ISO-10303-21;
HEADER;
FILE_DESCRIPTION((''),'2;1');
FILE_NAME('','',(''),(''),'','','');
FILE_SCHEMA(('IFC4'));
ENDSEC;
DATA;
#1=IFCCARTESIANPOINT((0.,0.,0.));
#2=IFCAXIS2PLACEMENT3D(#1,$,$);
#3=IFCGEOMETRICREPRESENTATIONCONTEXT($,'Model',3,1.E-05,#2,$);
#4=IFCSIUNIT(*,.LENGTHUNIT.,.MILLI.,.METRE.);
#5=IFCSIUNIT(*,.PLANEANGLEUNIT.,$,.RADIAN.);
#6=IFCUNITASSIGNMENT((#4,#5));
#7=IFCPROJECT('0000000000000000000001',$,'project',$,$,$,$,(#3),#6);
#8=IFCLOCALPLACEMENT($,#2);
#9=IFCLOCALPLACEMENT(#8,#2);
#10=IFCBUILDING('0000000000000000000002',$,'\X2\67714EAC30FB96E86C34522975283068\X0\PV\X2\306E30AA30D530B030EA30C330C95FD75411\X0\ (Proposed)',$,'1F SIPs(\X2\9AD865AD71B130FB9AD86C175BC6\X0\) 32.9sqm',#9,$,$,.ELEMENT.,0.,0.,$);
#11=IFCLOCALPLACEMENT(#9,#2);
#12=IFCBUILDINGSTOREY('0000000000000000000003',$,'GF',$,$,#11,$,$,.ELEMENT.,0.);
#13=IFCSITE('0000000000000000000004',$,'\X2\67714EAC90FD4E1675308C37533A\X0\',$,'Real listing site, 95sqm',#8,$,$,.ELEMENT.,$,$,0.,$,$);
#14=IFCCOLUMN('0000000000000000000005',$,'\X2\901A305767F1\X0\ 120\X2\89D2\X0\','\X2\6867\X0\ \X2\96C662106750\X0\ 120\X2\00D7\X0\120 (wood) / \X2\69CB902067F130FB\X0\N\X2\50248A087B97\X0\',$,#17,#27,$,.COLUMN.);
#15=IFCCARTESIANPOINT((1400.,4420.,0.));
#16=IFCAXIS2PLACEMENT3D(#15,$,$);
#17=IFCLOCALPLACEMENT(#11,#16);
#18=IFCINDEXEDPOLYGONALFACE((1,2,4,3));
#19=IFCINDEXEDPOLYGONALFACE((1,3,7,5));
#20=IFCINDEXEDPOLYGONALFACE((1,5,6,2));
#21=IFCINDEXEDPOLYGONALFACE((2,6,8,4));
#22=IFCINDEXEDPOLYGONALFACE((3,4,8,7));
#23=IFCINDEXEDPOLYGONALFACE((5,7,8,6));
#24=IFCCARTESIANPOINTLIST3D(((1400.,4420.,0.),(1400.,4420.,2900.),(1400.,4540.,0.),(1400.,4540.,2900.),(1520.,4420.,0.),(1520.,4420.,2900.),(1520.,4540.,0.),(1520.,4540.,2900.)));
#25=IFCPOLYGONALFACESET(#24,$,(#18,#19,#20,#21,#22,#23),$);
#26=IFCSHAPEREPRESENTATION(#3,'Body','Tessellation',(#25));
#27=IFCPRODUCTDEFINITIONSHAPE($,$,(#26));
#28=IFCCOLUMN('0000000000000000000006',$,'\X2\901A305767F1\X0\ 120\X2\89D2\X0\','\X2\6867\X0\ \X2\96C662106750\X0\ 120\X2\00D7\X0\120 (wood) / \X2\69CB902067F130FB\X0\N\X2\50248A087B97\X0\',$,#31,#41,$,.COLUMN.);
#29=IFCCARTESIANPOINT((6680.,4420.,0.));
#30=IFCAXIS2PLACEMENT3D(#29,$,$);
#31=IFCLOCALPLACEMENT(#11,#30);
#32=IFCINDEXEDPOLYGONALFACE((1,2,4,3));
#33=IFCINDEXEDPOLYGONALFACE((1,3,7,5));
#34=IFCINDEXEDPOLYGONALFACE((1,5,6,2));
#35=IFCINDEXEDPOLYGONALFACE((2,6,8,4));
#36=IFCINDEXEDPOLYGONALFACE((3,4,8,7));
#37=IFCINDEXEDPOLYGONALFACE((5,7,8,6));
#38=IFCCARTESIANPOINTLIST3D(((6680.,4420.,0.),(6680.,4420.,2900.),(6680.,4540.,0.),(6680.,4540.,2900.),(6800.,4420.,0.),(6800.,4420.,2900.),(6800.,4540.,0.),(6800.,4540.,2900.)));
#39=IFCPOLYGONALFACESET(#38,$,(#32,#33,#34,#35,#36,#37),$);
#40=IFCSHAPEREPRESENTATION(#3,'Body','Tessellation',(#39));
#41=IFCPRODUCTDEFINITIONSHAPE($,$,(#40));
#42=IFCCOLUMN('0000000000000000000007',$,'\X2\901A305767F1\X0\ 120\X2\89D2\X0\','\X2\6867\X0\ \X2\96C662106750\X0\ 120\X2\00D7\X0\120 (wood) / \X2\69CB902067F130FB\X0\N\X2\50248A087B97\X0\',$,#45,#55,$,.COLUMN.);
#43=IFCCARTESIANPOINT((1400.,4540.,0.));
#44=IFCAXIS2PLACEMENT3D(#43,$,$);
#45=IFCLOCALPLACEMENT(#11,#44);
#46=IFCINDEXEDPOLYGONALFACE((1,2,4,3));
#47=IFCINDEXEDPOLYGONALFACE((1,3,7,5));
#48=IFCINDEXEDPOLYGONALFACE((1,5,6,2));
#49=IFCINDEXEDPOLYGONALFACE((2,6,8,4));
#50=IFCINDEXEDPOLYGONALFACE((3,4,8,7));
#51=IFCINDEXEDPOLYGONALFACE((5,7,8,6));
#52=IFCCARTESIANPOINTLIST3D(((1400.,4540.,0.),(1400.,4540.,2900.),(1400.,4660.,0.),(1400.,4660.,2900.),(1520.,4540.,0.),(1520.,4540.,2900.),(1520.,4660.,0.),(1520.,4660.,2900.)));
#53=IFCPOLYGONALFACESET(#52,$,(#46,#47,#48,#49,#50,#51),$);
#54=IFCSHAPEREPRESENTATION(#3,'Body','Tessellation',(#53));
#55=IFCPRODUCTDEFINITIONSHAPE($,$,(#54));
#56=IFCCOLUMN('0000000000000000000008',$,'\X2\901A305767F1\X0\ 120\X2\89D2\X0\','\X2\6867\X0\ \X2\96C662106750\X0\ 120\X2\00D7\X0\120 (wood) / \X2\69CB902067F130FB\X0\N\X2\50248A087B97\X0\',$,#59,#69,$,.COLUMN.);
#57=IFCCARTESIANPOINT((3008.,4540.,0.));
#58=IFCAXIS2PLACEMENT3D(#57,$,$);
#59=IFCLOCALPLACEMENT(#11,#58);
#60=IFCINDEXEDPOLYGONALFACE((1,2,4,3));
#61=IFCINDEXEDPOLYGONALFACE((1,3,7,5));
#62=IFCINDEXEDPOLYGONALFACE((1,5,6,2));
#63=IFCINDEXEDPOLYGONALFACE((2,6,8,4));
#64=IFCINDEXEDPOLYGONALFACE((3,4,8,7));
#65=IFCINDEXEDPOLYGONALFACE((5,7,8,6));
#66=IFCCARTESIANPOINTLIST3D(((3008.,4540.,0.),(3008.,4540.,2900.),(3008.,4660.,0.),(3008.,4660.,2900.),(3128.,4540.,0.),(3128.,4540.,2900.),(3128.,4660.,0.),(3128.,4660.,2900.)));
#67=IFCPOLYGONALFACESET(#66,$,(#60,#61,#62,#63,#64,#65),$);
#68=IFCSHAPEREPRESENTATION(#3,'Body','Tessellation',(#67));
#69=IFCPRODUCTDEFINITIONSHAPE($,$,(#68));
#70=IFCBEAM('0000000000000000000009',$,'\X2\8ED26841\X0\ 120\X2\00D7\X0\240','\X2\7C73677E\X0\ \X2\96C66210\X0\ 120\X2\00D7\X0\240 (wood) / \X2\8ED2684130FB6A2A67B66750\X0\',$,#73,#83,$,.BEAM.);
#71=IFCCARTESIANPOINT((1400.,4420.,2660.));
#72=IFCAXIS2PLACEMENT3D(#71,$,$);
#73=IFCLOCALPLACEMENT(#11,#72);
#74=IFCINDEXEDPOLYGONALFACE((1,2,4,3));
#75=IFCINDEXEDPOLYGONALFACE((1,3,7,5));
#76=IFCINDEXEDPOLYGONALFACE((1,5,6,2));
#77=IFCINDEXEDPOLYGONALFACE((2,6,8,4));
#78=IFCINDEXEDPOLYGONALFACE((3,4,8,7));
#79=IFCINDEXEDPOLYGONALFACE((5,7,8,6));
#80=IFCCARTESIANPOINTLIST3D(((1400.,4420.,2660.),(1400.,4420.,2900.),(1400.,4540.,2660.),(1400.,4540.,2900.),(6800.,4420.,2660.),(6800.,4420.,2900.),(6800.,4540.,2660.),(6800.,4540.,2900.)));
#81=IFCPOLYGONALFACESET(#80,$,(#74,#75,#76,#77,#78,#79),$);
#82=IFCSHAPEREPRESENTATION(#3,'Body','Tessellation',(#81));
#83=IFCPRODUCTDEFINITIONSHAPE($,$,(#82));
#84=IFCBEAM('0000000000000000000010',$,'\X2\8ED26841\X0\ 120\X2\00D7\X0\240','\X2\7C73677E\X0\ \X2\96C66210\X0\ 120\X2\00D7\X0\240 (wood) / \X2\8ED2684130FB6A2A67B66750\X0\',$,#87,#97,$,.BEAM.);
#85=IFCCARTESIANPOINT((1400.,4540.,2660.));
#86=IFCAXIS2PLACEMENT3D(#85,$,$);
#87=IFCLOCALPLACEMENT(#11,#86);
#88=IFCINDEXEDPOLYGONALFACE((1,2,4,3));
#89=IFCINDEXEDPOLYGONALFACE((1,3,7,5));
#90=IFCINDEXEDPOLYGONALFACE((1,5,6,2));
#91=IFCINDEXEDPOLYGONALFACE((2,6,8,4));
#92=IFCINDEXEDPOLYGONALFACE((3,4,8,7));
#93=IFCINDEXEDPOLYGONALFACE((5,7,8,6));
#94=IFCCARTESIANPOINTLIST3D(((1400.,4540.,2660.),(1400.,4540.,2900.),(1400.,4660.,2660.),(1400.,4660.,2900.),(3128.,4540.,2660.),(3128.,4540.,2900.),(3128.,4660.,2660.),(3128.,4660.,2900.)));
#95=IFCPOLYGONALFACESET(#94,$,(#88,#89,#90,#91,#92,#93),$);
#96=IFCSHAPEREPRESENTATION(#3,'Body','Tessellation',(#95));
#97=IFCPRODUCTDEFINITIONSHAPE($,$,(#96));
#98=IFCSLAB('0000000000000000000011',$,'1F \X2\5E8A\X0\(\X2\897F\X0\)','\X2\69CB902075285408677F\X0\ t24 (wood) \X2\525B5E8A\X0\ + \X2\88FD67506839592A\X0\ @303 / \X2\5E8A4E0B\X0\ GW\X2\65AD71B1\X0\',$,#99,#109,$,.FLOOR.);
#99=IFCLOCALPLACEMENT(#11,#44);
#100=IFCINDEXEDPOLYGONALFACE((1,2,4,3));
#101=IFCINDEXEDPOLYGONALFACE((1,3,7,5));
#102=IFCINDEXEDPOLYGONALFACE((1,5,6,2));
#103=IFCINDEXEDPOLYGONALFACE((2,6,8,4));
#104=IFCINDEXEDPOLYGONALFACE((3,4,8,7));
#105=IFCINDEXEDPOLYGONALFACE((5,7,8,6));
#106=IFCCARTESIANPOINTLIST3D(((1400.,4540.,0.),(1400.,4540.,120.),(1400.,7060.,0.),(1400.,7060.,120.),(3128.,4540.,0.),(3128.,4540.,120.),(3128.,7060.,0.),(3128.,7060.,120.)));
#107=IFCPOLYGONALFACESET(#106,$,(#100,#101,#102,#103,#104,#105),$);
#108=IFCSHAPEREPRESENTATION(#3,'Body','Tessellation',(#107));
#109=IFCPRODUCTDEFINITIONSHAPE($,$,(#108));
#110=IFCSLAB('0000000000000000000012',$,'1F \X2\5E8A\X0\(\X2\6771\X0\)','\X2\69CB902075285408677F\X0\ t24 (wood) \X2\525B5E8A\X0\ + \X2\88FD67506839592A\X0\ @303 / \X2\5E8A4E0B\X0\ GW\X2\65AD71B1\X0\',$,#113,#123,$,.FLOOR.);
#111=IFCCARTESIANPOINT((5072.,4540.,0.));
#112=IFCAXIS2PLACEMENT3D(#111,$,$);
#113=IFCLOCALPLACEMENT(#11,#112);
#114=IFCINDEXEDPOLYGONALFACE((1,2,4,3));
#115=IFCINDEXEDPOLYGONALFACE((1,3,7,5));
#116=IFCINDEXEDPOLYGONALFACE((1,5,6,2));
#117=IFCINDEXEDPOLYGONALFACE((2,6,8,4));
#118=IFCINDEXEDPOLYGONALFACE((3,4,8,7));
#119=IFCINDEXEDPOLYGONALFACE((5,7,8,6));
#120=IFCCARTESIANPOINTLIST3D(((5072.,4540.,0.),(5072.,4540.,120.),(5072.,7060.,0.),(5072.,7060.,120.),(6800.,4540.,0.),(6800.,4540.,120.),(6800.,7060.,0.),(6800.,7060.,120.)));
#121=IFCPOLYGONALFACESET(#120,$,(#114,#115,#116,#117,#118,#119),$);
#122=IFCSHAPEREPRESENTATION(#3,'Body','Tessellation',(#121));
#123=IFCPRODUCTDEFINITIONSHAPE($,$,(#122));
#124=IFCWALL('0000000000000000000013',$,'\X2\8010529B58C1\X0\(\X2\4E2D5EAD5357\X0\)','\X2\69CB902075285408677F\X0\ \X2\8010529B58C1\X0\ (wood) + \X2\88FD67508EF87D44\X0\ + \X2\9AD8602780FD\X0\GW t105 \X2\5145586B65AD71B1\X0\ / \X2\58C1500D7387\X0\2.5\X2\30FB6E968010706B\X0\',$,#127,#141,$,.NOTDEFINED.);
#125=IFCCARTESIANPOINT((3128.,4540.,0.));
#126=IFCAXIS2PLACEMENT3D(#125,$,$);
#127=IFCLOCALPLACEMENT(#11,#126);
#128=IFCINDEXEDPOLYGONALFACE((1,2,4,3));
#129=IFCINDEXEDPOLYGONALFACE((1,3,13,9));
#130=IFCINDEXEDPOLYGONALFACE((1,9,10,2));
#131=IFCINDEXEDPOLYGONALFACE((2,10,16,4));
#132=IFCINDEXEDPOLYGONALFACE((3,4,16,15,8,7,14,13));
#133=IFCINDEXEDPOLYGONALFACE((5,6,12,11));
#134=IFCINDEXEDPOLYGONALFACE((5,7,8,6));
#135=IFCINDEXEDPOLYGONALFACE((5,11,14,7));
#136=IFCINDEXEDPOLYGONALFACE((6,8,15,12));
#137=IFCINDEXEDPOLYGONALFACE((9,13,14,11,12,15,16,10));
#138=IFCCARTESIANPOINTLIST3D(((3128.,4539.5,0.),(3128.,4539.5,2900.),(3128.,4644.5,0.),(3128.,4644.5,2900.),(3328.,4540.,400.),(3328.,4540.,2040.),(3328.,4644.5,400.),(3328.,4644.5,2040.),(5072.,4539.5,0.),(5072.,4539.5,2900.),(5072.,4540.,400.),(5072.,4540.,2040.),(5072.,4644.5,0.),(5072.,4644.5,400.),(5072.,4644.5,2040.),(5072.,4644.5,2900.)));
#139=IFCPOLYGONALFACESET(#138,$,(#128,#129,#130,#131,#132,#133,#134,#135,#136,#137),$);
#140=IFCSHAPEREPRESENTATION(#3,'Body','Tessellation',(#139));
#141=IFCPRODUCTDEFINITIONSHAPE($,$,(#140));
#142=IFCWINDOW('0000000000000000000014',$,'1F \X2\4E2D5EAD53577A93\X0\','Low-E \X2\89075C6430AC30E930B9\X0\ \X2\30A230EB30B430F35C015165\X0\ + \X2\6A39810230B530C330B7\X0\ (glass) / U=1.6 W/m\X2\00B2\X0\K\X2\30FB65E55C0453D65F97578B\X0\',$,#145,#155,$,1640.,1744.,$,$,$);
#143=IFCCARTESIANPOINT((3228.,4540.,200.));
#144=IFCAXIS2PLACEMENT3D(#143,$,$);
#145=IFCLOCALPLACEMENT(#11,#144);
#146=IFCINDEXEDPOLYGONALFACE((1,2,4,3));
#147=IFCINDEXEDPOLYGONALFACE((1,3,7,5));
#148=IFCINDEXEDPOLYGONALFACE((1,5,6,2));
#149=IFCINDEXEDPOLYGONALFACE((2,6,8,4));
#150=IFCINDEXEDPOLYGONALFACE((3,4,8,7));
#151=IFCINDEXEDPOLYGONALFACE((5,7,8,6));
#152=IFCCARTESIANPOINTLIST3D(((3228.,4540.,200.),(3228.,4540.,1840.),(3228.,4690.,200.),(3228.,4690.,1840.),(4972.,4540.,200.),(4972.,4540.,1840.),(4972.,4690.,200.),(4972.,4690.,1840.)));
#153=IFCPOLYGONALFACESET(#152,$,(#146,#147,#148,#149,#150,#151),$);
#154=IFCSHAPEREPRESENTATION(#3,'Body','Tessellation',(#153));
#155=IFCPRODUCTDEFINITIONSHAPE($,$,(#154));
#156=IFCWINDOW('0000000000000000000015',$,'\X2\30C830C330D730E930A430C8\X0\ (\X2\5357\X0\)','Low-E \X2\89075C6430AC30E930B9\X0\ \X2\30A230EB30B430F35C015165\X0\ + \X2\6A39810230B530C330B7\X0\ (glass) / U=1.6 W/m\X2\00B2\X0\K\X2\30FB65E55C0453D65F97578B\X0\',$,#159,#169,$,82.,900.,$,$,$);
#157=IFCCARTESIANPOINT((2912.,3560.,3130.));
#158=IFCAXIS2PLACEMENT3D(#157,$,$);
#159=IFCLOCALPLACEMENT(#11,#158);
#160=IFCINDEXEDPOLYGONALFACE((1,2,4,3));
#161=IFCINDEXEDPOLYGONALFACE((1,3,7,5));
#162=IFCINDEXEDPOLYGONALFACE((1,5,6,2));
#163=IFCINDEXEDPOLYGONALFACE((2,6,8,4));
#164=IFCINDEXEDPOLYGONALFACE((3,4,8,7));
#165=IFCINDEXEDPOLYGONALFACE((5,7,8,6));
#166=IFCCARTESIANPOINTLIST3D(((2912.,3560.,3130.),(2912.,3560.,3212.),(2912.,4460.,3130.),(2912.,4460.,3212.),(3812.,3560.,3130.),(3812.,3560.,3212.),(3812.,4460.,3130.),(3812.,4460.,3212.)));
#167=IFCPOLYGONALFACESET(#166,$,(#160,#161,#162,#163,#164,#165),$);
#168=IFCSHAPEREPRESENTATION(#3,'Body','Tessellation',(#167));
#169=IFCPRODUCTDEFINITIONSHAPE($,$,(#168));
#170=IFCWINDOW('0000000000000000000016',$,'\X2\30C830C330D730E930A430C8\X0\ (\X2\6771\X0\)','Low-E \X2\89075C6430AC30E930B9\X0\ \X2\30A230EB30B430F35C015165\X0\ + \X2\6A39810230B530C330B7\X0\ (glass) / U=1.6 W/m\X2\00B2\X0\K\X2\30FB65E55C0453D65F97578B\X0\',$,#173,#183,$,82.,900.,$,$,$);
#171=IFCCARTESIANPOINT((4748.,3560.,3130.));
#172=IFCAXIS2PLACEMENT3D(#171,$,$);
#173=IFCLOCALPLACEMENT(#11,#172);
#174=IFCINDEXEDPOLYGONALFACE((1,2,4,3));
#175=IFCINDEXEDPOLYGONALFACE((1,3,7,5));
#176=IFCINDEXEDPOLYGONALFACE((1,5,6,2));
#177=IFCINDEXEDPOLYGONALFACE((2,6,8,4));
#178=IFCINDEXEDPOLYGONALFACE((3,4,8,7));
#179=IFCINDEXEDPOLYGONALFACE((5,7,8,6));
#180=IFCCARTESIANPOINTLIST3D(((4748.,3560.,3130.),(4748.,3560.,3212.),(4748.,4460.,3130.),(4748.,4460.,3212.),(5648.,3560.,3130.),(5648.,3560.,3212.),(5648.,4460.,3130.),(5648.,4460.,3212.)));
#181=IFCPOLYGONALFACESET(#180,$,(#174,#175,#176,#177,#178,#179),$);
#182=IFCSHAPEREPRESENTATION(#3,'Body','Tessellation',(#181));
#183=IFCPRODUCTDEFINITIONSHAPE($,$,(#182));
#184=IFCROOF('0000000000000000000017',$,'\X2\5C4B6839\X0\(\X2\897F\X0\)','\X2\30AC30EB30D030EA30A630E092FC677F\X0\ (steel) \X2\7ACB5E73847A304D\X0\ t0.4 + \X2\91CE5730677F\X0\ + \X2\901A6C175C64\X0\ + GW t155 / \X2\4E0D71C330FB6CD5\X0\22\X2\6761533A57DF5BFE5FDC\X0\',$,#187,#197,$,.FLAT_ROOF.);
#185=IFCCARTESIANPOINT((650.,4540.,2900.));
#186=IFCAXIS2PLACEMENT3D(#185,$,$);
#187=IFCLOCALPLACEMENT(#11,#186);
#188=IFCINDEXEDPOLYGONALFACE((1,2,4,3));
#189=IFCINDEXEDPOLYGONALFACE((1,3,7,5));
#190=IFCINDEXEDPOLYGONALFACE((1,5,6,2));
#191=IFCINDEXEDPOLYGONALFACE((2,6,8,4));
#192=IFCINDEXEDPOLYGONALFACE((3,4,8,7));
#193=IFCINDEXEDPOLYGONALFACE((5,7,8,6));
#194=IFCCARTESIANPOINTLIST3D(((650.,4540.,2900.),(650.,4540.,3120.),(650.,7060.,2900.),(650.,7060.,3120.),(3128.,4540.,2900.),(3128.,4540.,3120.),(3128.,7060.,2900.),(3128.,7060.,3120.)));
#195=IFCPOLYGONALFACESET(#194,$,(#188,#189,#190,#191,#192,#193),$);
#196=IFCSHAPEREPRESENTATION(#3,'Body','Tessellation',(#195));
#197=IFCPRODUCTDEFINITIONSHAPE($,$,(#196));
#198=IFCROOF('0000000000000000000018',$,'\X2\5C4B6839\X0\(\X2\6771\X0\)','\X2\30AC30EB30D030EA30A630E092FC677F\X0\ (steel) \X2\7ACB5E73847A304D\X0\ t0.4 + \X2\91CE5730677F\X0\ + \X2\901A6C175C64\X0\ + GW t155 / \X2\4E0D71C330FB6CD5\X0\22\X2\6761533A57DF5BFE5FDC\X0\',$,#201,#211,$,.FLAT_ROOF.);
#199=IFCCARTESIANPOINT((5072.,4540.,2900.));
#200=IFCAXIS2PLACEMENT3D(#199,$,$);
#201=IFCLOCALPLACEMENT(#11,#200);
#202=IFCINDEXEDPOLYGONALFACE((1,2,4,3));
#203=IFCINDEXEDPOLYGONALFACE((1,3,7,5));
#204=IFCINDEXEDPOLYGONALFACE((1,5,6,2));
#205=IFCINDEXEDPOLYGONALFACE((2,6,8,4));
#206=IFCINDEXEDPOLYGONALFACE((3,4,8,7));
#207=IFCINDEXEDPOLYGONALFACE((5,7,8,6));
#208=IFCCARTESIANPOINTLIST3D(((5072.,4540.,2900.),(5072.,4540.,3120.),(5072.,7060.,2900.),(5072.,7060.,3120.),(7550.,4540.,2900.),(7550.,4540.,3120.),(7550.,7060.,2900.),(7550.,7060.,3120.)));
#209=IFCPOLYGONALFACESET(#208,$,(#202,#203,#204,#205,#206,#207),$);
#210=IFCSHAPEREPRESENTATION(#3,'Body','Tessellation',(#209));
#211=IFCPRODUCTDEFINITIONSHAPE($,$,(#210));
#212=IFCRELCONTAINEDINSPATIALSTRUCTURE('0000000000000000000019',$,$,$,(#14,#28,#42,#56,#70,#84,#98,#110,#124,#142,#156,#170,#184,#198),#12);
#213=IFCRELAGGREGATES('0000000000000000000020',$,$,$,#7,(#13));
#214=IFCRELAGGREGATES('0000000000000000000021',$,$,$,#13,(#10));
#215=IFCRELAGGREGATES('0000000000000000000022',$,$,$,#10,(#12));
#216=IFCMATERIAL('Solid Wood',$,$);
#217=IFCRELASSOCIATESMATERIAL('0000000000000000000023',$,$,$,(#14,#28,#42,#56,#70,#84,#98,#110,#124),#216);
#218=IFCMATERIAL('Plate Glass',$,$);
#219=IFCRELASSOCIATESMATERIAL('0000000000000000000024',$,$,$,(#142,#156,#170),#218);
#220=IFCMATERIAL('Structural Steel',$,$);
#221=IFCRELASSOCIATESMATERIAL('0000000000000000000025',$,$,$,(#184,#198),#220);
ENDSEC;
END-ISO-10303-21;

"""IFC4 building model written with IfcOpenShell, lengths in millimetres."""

from ifc_helpers import new_model, si_unit, frame, frame_2d, origin, place, context, project, spatial, rectangle, extrude, material, element, fill, save


model = new_model("IFC4")

# Units and contexts
model_context = context("Model", 3, precision=1e-05, world=origin())
ifc_project = project(units=[si_unit("LENGTHUNIT", "METRE", prefix="MILLI"), si_unit("PLANEANGLEUNIT", "RADIAN")], contexts=[model_context])

# Site, building, storey
site_placement = place(None, origin())
site = spatial("IfcSite", under=ifc_project, at=site_placement, Name="東京都世田谷区", ObjectType="Real listing site, 95sqm", CompositionType="ELEMENT", RefElevation=0.0)
building_placement = place(site_placement, origin())
building = spatial("IfcBuilding", under=site, at=building_placement, Name="東京・雨水利用とPVのオフグリッド志向 (Proposed)", ObjectType="1F SIPs(高断熱・高気密) 32.9sqm", CompositionType="ELEMENT", ElevationOfRefHeight=0.0, ElevationOfTerrain=0.0)
storey_placement = place(building_placement, origin())
storey = spatial("IfcBuildingStorey", under=building, at=storey_placement, Name="GF", CompositionType="ELEMENT", Elevation=0.0)

# Columns
ifc_material_1 = material(Name="Solid Wood")
column_1_placement = place(storey_placement, frame((1400.0, 4420.0, 0.0)))
element("IfcColumn", 1, at=column_1_placement, inside=storey, material=ifc_material_1, Name="通し柱 120角", Description="桧 集成材 120×120 (wood) / 構造柱・N値計算", PredefinedType="COLUMN", context=model_context, shape_type="SweptSolid", body=[
    extrude(rectangle(XDim=120.0, YDim=120.0, at=frame_2d((60.0, 60.0))), frame((1400.0, 4420.0, 0.0)), (0.0, 0.0, 1.0), 2900.0),
])
column_2_placement = place(storey_placement, frame((6680.0, 4420.0, 0.0)))
element("IfcColumn", 2, at=column_2_placement, inside=storey, material=ifc_material_1, Name="通し柱 120角", Description="桧 集成材 120×120 (wood) / 構造柱・N値計算", PredefinedType="COLUMN", context=model_context, shape_type="SweptSolid", body=[
    extrude(rectangle(XDim=120.0, YDim=120.0, at=frame_2d((60.0, 60.0))), frame((6680.0, 4420.0, 0.0)), (0.0, 0.0, 1.0), 2900.0),
])
column_3_placement = place(storey_placement, frame((1400.0, 4540.0, 0.0)))
element("IfcColumn", 3, at=column_3_placement, inside=storey, material=ifc_material_1, Name="通し柱 120角", Description="桧 集成材 120×120 (wood) / 構造柱・N値計算", PredefinedType="COLUMN", context=model_context, shape_type="SweptSolid", body=[
    extrude(rectangle(XDim=120.0, YDim=120.0, at=frame_2d((60.0, 60.0))), frame((1400.0, 4540.0, 0.0)), (0.0, 0.0, 1.0), 2900.0),
])
column_4_placement = place(storey_placement, frame((3008.0, 4540.0, 0.0)))
element("IfcColumn", 4, at=column_4_placement, inside=storey, material=ifc_material_1, Name="通し柱 120角", Description="桧 集成材 120×120 (wood) / 構造柱・N値計算", PredefinedType="COLUMN", context=model_context, shape_type="SweptSolid", body=[
    extrude(rectangle(XDim=120.0, YDim=120.0, at=frame_2d((60.0, 60.0))), frame((3008.0, 4540.0, 0.0)), (0.0, 0.0, 1.0), 2900.0),
])

# Beams
beam_1_placement = place(storey_placement, frame((1400.0, 4420.0, 2660.0)))
element("IfcBeam", 5, at=beam_1_placement, inside=storey, material=ifc_material_1, Name="軒桁 120×240", Description="米松 集成 120×240 (wood) / 軒桁・横架材", PredefinedType="BEAM", context=model_context, shape_type="SweptSolid", body=[
    extrude(rectangle(XDim=5400.0, YDim=120.0, at=frame_2d((2700.0, 60.0))), frame((1400.0, 4420.0, 2660.0)), (0.0, 0.0, 1.0), 240.0),
])
beam_2_placement = place(storey_placement, frame((1400.0, 4540.0, 2660.0)))
element("IfcBeam", 6, at=beam_2_placement, inside=storey, material=ifc_material_1, Name="軒桁 120×240", Description="米松 集成 120×240 (wood) / 軒桁・横架材", PredefinedType="BEAM", context=model_context, shape_type="SweptSolid", body=[
    extrude(rectangle(XDim=1728.0, YDim=120.0, at=frame_2d((864.0, 60.0))), frame((1400.0, 4540.0, 2660.0)), (0.0, 0.0, 1.0), 240.0),
])

# Slabs
slab_1_placement = place(storey_placement, frame((1400.0, 4540.0, 0.0)))
element("IfcSlab", 7, at=slab_1_placement, inside=storey, material=ifc_material_1, Name="1F 床(西)", Description="構造用合板 t24 (wood) 剛床 + 製材根太 @303 / 床下 GW断熱", PredefinedType="FLOOR", context=model_context, shape_type="SweptSolid", body=[
    extrude(rectangle(XDim=1728.0, YDim=2520.0, at=frame_2d((864.0, 1260.0))), frame((1400.0, 4540.0, 0.0)), (0.0, 0.0, 1.0), 120.0),
])
slab_2_placement = place(storey_placement, frame((5072.0, 4540.0, 0.0)))
element("IfcSlab", 8, at=slab_2_placement, inside=storey, material=ifc_material_1, Name="1F 床(東)", Description="構造用合板 t24 (wood) 剛床 + 製材根太 @303 / 床下 GW断熱", PredefinedType="FLOOR", context=model_context, shape_type="SweptSolid", body=[
    extrude(rectangle(XDim=1728.0, YDim=2520.0, at=frame_2d((864.0, 1260.0))), frame((5072.0, 4540.0, 0.0)), (0.0, 0.0, 1.0), 120.0),
])

# Wall, opening, window
wall_1_placement = place(storey_placement, frame((3128.0, 4540.0, 0.0)))
wall_1 = element("IfcWall", 9, at=wall_1_placement, inside=storey, material=ifc_material_1, Name="耐力壁(中庭南)", Description="構造用合板 耐力壁 (wood) + 製材軸組 + 高性能GW t105 充填断熱 / 壁倍率2.5・準耐火", PredefinedType="NOTDEFINED", context=model_context, shape_type="SweptSolid", body=[
    extrude(rectangle(XDim=1944.0, YDim=105.0, at=frame_2d((972.0, 52.0))), frame((3128.0, 4540.0, 0.0)), (0.0, 0.0, 1.0), 2900.0),
])
opening_placement = place(storey_placement, frame((3228.0, 4540.0, 200.0)))
opening = element("IfcOpeningElement", 10, at=opening_placement, cuts=wall_1, PredefinedType="NOTDEFINED", context=model_context, shape_type="SweptSolid", body=[
    extrude(rectangle(XDim=1744.0, YDim=150.0, at=frame_2d((872.0, 75.0))), frame((3228.0, 4540.0, 200.0)), (0.0, 0.0, 1.0), 1640.0),
])
ifc_material_2 = material(Name="Plate Glass")
window_1_placement = place(storey_placement, frame((3228.0, 4540.0, 200.0)))
window_1 = element("IfcWindow", 11, at=window_1_placement, inside=storey, material=ifc_material_2, Name="1F 中庭南窓", Description="Low-E 複層ガラス アルゴン封入 + 樹脂サッシ (glass) / U=1.6 W/m²K・日射取得型", OverallHeight=1640.0, OverallWidth=1744.0, context=model_context, shape_type="SweptSolid", body=[
    extrude(rectangle(XDim=1744.0, YDim=150.0, at=frame_2d((872.0, 75.0))), frame((3228.0, 4540.0, 200.0)), (0.0, 0.0, 1.0), 1640.0),
])
fill(opening, window_1)

# Windows
window_2_placement = place(storey_placement, frame((2912.0, 3560.0, 3130.0)))
element("IfcWindow", 12, at=window_2_placement, inside=storey, material=ifc_material_2, Name="トップライト (南)", Description="Low-E 複層ガラス アルゴン封入 + 樹脂サッシ (glass) / U=1.6 W/m²K・日射取得型", OverallHeight=82.0, OverallWidth=900.0, context=model_context, shape_type="SweptSolid", body=[
    extrude(rectangle(XDim=900.0, YDim=900.0, at=frame_2d((450.0, 450.0))), frame((2912.0, 3560.0, 3130.0)), (0.0, 0.0, 1.0), 82.0),
])
window_3_placement = place(storey_placement, frame((4748.0, 3560.0, 3130.0)))
element("IfcWindow", 13, at=window_3_placement, inside=storey, material=ifc_material_2, Name="トップライト (東)", Description="Low-E 複層ガラス アルゴン封入 + 樹脂サッシ (glass) / U=1.6 W/m²K・日射取得型", OverallHeight=82.0, OverallWidth=900.0, context=model_context, shape_type="SweptSolid", body=[
    extrude(rectangle(XDim=900.0, YDim=900.0, at=frame_2d((450.0, 450.0))), frame((4748.0, 3560.0, 3130.0)), (0.0, 0.0, 1.0), 82.0),
])

# Roofs
ifc_material_3 = material(Name="Structural Steel")
roof_1_placement = place(storey_placement, frame((650.0, 4540.0, 2900.0)))
element("IfcRoof", 14, at=roof_1_placement, inside=storey, material=ifc_material_3, Name="屋根(西)", Description="ガルバリウム鋼板 (steel) 立平葺き t0.4 + 野地板 + 通気層 + GW t155 / 不燃・法22条区域対応", PredefinedType="FLAT_ROOF", context=model_context, shape_type="SweptSolid", body=[
    extrude(rectangle(XDim=2478.0, YDim=2520.0, at=frame_2d((1239.0, 1260.0))), frame((650.0, 4540.0, 2900.0)), (0.0, 0.0, 1.0), 220.0),
])
roof_2_placement = place(storey_placement, frame((5072.0, 4540.0, 2900.0)))
element("IfcRoof", 15, at=roof_2_placement, inside=storey, material=ifc_material_3, Name="屋根(東)", Description="ガルバリウム鋼板 (steel) 立平葺き t0.4 + 野地板 + 通気層 + GW t155 / 不燃・法22条区域対応", PredefinedType="FLAT_ROOF", context=model_context, shape_type="SweptSolid", body=[
    extrude(rectangle(XDim=2478.0, YDim=2520.0, at=frame_2d((1239.0, 1260.0))), frame((5072.0, 4540.0, 2900.0)), (0.0, 0.0, 1.0), 220.0),
])

save(model, "model.ifc")
